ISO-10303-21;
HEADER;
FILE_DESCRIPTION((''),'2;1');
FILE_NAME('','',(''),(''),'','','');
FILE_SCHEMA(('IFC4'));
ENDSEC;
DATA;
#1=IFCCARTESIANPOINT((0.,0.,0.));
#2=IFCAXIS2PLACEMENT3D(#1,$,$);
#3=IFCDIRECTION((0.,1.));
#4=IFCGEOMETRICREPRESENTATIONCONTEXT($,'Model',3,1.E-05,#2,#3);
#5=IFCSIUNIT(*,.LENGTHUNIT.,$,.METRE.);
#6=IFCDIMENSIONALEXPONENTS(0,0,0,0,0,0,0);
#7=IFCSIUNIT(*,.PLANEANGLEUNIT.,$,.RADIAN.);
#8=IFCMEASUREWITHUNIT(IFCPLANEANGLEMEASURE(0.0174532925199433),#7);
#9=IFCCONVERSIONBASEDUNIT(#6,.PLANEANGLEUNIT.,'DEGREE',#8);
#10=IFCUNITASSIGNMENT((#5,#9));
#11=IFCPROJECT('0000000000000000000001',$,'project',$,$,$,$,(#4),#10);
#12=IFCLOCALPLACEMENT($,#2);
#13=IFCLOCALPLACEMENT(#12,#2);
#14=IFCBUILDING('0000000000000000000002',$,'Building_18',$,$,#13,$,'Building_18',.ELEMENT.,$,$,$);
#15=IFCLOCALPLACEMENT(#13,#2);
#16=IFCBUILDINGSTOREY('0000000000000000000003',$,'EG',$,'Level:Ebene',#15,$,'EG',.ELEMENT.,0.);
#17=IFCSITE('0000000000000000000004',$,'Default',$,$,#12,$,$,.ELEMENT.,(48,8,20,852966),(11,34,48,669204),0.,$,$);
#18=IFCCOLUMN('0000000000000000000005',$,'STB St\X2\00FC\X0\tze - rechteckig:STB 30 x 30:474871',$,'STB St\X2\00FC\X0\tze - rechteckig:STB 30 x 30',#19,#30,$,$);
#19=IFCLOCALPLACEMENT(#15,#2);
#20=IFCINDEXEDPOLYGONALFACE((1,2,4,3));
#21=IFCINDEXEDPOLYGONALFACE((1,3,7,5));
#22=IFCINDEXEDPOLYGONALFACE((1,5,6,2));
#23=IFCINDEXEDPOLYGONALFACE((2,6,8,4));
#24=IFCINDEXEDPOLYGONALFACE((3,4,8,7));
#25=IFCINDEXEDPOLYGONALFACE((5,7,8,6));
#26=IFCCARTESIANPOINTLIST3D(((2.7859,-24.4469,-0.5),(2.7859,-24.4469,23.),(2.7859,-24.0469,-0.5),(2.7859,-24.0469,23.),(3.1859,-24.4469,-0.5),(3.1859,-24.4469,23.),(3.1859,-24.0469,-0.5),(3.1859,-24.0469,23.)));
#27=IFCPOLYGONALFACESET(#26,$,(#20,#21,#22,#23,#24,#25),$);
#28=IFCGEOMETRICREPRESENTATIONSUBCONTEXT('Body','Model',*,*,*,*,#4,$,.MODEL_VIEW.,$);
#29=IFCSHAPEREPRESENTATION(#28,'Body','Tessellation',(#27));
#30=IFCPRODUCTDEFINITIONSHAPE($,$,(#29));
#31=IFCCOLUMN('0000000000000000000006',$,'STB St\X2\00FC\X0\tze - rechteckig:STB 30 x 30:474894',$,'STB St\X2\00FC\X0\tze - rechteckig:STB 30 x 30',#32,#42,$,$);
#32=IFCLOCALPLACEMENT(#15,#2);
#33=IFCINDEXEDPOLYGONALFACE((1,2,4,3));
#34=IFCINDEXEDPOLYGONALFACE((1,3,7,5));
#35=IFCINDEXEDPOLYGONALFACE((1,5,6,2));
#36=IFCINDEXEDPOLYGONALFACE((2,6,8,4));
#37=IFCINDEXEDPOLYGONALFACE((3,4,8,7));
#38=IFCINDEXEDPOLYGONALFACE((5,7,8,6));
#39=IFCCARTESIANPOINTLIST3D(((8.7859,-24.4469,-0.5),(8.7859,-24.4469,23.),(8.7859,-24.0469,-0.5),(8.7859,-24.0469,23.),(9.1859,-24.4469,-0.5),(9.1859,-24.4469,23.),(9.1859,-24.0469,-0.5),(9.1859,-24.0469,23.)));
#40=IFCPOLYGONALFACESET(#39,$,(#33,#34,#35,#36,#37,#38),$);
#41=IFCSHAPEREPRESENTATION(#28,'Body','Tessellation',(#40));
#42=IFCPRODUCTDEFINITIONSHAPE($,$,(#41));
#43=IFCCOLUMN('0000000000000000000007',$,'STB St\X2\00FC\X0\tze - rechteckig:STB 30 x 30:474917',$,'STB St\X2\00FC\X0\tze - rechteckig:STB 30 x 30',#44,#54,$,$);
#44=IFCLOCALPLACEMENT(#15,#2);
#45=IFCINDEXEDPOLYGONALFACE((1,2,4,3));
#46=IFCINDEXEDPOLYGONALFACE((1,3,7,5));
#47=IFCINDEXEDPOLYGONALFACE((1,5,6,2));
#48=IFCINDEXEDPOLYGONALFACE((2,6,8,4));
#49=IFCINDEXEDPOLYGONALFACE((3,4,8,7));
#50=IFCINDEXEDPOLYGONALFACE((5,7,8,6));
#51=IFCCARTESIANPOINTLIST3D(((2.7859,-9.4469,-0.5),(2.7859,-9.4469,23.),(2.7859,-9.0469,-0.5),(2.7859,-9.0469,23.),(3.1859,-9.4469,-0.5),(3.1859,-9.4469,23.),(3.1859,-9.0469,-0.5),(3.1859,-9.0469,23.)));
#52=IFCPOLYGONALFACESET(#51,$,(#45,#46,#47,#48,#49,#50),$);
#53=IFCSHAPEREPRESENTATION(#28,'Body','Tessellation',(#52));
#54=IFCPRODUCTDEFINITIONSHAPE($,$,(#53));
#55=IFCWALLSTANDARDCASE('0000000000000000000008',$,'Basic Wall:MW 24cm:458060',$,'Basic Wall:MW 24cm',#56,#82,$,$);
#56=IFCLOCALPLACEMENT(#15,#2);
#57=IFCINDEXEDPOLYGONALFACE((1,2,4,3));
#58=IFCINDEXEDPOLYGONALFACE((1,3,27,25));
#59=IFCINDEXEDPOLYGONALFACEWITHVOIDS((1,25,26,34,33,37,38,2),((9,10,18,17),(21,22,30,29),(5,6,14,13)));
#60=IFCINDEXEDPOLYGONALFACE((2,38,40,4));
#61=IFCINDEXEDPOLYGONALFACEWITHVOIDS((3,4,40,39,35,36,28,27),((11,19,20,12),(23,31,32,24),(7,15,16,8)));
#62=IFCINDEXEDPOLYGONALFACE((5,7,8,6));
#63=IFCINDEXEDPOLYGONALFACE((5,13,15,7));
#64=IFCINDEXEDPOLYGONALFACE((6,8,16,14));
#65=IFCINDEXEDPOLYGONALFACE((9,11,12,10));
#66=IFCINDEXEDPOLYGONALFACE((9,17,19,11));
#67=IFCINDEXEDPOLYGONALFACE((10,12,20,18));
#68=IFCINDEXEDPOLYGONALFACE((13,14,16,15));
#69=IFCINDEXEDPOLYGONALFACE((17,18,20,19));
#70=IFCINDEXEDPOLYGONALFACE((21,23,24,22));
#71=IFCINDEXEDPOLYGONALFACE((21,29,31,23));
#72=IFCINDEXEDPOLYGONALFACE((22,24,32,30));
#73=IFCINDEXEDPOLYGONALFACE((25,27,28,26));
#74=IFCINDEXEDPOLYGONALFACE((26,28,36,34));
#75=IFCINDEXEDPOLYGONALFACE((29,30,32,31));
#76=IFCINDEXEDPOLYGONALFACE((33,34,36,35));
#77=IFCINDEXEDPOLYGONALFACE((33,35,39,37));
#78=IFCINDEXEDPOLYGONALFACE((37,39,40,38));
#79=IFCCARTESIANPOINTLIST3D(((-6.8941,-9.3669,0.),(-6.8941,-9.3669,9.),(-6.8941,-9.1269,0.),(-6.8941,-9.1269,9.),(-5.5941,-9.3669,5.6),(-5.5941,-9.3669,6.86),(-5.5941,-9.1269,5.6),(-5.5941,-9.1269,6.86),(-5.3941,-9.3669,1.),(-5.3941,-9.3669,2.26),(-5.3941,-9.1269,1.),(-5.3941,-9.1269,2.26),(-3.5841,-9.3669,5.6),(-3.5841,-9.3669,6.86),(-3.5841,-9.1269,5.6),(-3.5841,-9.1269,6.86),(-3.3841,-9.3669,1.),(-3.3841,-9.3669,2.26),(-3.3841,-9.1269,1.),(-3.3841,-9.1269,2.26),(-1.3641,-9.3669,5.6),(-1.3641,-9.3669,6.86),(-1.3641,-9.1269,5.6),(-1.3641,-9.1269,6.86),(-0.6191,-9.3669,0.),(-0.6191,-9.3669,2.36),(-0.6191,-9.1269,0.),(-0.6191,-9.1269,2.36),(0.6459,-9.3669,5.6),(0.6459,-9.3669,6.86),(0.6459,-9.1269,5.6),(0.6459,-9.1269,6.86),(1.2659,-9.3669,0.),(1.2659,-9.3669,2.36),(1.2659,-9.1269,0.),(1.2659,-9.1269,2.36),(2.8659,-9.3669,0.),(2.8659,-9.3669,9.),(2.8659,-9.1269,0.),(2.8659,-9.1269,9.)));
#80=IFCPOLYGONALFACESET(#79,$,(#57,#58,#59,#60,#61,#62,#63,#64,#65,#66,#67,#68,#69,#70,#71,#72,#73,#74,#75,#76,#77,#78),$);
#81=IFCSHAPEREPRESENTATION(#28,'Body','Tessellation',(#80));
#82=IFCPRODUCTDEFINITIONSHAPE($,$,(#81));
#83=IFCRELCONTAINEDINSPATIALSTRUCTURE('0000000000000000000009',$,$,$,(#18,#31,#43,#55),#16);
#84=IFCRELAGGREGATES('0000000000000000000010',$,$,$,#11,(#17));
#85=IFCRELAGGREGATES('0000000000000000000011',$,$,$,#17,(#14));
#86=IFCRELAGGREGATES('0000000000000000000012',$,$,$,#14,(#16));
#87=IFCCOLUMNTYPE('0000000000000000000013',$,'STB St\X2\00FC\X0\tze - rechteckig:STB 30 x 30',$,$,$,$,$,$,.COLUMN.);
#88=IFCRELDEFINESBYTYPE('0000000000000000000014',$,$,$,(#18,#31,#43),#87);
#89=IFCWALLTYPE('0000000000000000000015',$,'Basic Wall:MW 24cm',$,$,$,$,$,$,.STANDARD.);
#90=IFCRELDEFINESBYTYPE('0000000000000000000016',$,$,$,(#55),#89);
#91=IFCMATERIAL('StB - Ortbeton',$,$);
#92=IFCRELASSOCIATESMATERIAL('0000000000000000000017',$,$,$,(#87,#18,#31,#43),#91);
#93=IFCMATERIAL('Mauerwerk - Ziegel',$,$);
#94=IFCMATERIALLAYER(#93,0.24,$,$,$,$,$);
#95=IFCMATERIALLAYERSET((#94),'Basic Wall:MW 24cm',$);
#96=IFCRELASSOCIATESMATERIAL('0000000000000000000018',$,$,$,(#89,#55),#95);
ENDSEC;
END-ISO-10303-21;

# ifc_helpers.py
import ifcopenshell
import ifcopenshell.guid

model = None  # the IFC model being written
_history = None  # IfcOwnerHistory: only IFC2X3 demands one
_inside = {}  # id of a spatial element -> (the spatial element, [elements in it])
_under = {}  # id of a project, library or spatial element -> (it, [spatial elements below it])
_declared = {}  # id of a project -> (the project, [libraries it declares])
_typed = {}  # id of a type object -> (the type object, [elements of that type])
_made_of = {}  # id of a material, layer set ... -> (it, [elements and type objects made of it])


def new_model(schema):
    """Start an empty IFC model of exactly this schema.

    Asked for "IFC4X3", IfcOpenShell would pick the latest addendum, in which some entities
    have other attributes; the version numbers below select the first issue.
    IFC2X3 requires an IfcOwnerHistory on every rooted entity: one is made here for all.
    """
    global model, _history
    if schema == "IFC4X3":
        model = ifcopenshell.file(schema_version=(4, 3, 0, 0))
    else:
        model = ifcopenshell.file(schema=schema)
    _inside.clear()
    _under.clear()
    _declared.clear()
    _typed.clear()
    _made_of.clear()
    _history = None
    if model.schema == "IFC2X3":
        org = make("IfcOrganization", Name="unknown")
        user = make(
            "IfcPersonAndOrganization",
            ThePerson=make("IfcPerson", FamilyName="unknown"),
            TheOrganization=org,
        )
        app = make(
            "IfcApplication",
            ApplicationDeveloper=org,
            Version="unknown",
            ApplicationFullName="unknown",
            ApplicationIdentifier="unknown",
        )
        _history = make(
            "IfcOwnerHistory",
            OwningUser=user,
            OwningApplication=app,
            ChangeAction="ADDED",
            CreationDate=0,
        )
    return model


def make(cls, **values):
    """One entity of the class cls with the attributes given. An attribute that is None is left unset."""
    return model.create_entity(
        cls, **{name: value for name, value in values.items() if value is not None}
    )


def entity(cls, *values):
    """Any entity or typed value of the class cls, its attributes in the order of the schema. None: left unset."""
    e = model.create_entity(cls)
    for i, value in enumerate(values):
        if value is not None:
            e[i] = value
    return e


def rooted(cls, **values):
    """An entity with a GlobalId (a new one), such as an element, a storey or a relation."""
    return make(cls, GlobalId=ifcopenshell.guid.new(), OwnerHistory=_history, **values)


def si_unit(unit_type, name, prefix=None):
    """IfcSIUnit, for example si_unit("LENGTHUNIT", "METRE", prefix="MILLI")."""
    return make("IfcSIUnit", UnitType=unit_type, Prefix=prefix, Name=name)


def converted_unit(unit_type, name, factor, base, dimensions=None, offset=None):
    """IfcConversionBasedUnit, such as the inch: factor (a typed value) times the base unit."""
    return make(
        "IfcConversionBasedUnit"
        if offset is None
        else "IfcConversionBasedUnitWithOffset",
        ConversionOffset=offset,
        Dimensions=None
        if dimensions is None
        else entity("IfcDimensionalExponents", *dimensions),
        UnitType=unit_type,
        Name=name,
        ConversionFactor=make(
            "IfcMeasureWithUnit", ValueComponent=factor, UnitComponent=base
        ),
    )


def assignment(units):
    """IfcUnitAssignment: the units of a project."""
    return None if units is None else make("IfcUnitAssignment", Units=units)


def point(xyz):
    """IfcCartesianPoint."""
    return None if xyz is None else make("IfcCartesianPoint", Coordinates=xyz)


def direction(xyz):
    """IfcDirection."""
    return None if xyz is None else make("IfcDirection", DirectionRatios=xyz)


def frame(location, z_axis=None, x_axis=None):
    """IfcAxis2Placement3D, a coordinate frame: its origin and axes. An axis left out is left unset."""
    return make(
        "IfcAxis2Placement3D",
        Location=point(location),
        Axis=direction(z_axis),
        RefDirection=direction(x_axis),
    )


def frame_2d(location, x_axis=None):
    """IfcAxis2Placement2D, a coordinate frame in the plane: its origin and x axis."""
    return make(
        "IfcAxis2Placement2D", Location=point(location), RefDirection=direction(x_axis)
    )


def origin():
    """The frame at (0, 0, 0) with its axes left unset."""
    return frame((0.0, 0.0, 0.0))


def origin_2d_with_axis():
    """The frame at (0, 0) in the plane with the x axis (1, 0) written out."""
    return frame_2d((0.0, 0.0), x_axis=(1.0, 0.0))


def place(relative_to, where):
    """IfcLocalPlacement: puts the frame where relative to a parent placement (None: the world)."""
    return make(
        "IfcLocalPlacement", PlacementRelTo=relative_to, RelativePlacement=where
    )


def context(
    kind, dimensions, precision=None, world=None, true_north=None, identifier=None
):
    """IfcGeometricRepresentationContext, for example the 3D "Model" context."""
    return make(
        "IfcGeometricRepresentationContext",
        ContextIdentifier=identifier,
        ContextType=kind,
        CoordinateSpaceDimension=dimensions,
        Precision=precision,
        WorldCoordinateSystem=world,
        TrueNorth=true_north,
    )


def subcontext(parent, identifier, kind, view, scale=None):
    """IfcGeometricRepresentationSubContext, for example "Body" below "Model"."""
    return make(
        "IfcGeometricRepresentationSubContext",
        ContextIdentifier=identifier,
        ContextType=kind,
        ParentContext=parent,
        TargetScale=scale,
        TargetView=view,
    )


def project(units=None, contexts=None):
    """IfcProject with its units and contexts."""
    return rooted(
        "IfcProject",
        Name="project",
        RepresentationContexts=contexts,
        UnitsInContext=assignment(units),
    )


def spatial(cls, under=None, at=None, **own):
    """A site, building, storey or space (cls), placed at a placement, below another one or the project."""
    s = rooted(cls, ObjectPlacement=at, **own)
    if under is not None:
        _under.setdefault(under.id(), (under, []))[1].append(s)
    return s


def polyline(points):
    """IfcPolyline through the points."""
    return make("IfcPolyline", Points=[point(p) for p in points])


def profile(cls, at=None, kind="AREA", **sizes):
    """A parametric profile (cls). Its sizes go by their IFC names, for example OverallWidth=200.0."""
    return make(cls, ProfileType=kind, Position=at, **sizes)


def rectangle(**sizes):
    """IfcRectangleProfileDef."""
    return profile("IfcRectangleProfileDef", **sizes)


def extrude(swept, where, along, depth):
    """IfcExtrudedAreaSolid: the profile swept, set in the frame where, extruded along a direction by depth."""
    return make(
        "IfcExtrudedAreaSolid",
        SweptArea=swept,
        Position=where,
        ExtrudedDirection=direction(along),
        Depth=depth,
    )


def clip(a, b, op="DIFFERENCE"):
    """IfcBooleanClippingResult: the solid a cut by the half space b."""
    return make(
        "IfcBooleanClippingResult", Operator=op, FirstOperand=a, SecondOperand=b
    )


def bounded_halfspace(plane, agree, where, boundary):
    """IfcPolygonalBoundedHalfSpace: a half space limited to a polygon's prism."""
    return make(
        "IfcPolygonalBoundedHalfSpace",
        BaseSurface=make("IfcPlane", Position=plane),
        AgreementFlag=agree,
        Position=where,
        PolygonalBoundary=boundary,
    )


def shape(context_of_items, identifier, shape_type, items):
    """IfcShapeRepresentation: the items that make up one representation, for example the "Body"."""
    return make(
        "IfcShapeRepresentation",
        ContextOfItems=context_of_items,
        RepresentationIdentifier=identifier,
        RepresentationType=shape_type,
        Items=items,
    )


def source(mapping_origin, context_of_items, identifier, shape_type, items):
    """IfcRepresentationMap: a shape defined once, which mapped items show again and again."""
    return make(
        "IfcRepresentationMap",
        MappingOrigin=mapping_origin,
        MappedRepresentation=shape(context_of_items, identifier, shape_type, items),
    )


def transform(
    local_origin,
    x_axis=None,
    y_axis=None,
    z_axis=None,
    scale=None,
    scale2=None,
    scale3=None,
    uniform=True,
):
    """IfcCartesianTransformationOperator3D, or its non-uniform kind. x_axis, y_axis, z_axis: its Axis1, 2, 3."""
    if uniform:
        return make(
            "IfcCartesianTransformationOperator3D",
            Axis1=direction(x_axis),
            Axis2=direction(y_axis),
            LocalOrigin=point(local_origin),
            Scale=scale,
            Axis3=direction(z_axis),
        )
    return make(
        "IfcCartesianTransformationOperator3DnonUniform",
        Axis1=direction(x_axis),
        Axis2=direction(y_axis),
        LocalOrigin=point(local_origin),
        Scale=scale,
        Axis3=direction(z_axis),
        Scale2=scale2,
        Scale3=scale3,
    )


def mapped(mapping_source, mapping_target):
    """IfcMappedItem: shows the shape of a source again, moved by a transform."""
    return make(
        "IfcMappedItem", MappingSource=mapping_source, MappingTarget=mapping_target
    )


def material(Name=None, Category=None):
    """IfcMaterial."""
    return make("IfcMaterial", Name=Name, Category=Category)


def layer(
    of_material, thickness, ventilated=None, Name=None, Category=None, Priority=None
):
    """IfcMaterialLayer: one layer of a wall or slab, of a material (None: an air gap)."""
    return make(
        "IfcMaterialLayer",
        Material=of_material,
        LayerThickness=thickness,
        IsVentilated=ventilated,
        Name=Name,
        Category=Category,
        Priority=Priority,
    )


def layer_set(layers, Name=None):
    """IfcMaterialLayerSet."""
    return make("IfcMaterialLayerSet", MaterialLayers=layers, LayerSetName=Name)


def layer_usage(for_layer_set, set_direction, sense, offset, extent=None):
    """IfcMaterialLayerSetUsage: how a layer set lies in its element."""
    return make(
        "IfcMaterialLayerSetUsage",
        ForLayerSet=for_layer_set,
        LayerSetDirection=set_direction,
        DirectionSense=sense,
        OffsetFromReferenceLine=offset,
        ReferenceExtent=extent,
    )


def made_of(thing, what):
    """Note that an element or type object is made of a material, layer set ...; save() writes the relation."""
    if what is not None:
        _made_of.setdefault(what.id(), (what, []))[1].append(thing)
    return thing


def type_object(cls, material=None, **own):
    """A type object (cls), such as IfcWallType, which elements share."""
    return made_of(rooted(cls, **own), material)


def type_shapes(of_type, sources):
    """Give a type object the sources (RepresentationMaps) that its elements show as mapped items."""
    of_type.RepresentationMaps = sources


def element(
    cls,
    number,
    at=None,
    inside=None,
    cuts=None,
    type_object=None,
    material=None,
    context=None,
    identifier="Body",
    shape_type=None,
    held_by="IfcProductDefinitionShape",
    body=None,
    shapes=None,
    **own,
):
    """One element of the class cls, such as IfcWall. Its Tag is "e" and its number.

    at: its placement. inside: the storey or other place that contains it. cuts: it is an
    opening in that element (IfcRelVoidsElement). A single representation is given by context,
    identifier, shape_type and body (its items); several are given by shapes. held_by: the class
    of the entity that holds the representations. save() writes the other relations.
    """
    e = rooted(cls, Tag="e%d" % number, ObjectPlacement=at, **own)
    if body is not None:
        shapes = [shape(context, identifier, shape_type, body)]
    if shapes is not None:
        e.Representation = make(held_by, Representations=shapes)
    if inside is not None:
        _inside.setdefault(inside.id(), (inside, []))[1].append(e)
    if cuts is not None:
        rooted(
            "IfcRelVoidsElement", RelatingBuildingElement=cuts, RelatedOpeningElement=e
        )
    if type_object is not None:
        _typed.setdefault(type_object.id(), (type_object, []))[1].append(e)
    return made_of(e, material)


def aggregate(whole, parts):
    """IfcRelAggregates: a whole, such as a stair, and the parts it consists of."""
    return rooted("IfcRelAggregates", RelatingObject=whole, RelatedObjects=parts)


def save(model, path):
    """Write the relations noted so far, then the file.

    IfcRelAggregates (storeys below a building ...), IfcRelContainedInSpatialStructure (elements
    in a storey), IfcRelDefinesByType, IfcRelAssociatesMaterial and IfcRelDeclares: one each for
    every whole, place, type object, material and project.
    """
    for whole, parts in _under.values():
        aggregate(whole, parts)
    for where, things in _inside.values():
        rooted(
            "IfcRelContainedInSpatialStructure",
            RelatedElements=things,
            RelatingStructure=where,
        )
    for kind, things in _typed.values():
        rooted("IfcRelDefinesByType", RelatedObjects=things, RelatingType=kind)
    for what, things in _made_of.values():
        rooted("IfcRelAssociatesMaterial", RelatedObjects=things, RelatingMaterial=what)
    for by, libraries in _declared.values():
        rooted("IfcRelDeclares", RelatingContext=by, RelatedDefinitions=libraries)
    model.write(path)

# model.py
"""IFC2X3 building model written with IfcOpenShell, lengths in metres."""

from ifc_helpers import new_model, entity, si_unit, converted_unit, direction, frame, frame_2d, origin, origin_2d_with_axis, place, context, subcontext, project, spatial, polyline, rectangle, extrude, clip, bounded_halfspace, source, transform, mapped, material, layer, layer_set, layer_usage, type_object, type_shapes, element, save


model = new_model("IFC2X3")

# Units and contexts
model_context = context("Model", 3, precision=1e-05, world=origin(), true_north=direction((0.0, 1.0)))
body_context = subcontext(model_context, "Body", "Model", "MODEL_VIEW")
ifc_project = project(units=[si_unit("LENGTHUNIT", "METRE"), converted_unit("PLANEANGLEUNIT", "DEGREE", entity("IfcPlaneAngleMeasure", 0.0174532925199433), si_unit("PLANEANGLEUNIT", "RADIAN"), dimensions=[0, 0, 0, 0, 0, 0, 0])], contexts=[model_context])

# Site, building, storey
site_placement = place(None, origin())
site = spatial("IfcSite", under=ifc_project, at=site_placement, Name="Default", CompositionType="ELEMENT", RefLatitude=(48, 8, 20, 852966), RefLongitude=(11, 34, 48, 669204), RefElevation=0.0)
building_placement = place(site_placement, origin())
building = spatial("IfcBuilding", under=site, at=building_placement, Name="Building_18", LongName="Building_18", CompositionType="ELEMENT")
storey_placement = place(building_placement, origin())
storey = spatial("IfcBuildingStorey", under=building, at=storey_placement, Name="EG", ObjectType="Level:Ebene", LongName="EG", CompositionType="ELEMENT", Elevation=0.0)

# Columns
ifc_material_1 = material(Name="StB - Ortbeton")
column_type = type_object("IfcColumnType", Name="STB Stütze - rechteckig:STB 30 x 30", PredefinedType="COLUMN", material=ifc_material_1)
shared_shape = source(origin(), body_context, "Body", "SweptSolid", [
    extrude(rectangle(XDim=0.4, YDim=0.4, at=origin_2d_with_axis()), frame((0.0, 0.0, -0.5), z_axis=(0.0, 0.0, 1.0), x_axis=(-1.0, 0.0, 0.0)), (0.0, 0.0, 1.0), 23.5),
])
type_shapes(column_type, [shared_shape])
for number, where, name in (
    (1, (2.9859, -24.2469, 0.0), "STB Stütze - rechteckig:STB 30 x 30:474871"),
    (2, (8.9859, -24.2469, 0.0), "STB Stütze - rechteckig:STB 30 x 30:474894"),
    (3, (2.9859, -9.2469, 0.0), "STB Stütze - rechteckig:STB 30 x 30:474917"),
):
    element("IfcColumn", number, at=place(storey_placement, frame(where)), inside=storey, type_object=column_type, material=ifc_material_1, Name=name, ObjectType="STB Stütze - rechteckig:STB 30 x 30", context=body_context, shape_type="MappedRepresentation", body=[
        mapped(shared_shape, transform((0.0, 0.0, 0.0), scale=1.0)),
    ])

# Wall, openings
ifc_material_2 = material(Name="Mauerwerk - Ziegel")
ifc_layer = layer(ifc_material_2, 0.24)
ifc_layer_set = layer_set([ifc_layer], Name="Basic Wall:MW 24cm")
ifc_layer_usage_1 = layer_usage(ifc_layer_set, "AXIS2", "NEGATIVE", 0.12)
wall_type = type_object("IfcWallType", Name="Basic Wall:MW 24cm", PredefinedType="STANDARD", material=ifc_layer_set)
wall_1_placement = place(storey_placement, frame((2.8659, -9.2469, 0.0), z_axis=(0.0, 0.0, 1.0), x_axis=(-1.0, 0.0, 0.0)))
wall_1 = element("IfcWallStandardCase", 4, at=wall_1_placement, inside=storey, type_object=wall_type, material=ifc_layer_usage_1, Name="Basic Wall:MW 24cm:458060", ObjectType="Basic Wall:MW 24cm", context=body_context, shape_type="Clipping", body=[
    clip(extrude(rectangle(XDim=9.76, YDim=0.24, at=frame_2d((4.88, 0.0), x_axis=(1.0, 0.0))), origin(), (0.0, 0.0, 1.0), 9.0), bounded_halfspace(frame((0.0, -0.12, 9.0), z_axis=(0.0, 0.0, -1.0), x_axis=(0.0, 1.0, 0.0)), True, frame((0.0, -0.12, 9.0)), polyline([(0.0, 0.0), (9.76, 0.0), (9.76, 0.24), (0.0, 0.24), (0.0, 0.0)]))),
])
opening_1_placement = place(wall_1_placement, frame((3.485, 0.12, 0.0)))
element("IfcOpeningElement", 5, at=opening_1_placement, cuts=wall_1, ObjectType="Opening", context=body_context, shape_type="SweptSolid", body=[
    extrude(rectangle(XDim=2.36, YDim=1.885, at=frame_2d((1.18, 0.9425), x_axis=(1.0, 0.0))), frame((0.0, 0.0, 0.0), z_axis=(0.0, -1.0, 0.0), x_axis=(0.0, 0.0, 1.0)), (0.0, 0.0, 1.0), 0.24),
])
opening_2_placement = place(wall_1_placement, frame((8.26, 0.12, 1.0)))
element("IfcOpeningElement", 6, at=opening_2_placement, cuts=wall_1, ObjectType="Opening", context=body_context, shape_type="SweptSolid", body=[
    extrude(rectangle(XDim=1.26, YDim=2.01, at=frame_2d((0.63, 1.005), x_axis=(1.0, 0.0))), frame((0.0, 0.0, 0.0), z_axis=(0.0, -1.0, 0.0), x_axis=(0.0, 0.0, 1.0)), (0.0, 0.0, 1.0), 0.24),
])
opening_3_placement = place(wall_1_placement, frame((6.45, -0.12, 5.6)))
element("IfcOpeningElement", 7, at=opening_3_placement, cuts=wall_1, ObjectType="Opening", context=body_context, shape_type="SweptSolid", body=[
    extrude(rectangle(XDim=1.26, YDim=2.01, at=frame_2d((0.63, 1.005), x_axis=(1.0, 0.0))), frame((0.0, 0.0, 0.0), z_axis=(0.0, 1.0, 0.0), x_axis=(0.0, 0.0, 1.0)), (0.0, 0.0, 1.0), 0.24),
])
opening_4_placement = place(wall_1_placement, frame((4.23, 0.12, 5.6)))
element("IfcOpeningElement", 8, at=opening_4_placement, cuts=wall_1, ObjectType="Opening", context=body_context, shape_type="SweptSolid", body=[
    extrude(rectangle(XDim=1.26, YDim=2.01, at=frame_2d((0.63, 1.005), x_axis=(1.0, 0.0))), frame((0.0, 0.0, 0.0), z_axis=(0.0, -1.0, 0.0), x_axis=(0.0, 0.0, 1.0)), (0.0, 0.0, 1.0), 0.24),
])

save(model, "model.ifc")
